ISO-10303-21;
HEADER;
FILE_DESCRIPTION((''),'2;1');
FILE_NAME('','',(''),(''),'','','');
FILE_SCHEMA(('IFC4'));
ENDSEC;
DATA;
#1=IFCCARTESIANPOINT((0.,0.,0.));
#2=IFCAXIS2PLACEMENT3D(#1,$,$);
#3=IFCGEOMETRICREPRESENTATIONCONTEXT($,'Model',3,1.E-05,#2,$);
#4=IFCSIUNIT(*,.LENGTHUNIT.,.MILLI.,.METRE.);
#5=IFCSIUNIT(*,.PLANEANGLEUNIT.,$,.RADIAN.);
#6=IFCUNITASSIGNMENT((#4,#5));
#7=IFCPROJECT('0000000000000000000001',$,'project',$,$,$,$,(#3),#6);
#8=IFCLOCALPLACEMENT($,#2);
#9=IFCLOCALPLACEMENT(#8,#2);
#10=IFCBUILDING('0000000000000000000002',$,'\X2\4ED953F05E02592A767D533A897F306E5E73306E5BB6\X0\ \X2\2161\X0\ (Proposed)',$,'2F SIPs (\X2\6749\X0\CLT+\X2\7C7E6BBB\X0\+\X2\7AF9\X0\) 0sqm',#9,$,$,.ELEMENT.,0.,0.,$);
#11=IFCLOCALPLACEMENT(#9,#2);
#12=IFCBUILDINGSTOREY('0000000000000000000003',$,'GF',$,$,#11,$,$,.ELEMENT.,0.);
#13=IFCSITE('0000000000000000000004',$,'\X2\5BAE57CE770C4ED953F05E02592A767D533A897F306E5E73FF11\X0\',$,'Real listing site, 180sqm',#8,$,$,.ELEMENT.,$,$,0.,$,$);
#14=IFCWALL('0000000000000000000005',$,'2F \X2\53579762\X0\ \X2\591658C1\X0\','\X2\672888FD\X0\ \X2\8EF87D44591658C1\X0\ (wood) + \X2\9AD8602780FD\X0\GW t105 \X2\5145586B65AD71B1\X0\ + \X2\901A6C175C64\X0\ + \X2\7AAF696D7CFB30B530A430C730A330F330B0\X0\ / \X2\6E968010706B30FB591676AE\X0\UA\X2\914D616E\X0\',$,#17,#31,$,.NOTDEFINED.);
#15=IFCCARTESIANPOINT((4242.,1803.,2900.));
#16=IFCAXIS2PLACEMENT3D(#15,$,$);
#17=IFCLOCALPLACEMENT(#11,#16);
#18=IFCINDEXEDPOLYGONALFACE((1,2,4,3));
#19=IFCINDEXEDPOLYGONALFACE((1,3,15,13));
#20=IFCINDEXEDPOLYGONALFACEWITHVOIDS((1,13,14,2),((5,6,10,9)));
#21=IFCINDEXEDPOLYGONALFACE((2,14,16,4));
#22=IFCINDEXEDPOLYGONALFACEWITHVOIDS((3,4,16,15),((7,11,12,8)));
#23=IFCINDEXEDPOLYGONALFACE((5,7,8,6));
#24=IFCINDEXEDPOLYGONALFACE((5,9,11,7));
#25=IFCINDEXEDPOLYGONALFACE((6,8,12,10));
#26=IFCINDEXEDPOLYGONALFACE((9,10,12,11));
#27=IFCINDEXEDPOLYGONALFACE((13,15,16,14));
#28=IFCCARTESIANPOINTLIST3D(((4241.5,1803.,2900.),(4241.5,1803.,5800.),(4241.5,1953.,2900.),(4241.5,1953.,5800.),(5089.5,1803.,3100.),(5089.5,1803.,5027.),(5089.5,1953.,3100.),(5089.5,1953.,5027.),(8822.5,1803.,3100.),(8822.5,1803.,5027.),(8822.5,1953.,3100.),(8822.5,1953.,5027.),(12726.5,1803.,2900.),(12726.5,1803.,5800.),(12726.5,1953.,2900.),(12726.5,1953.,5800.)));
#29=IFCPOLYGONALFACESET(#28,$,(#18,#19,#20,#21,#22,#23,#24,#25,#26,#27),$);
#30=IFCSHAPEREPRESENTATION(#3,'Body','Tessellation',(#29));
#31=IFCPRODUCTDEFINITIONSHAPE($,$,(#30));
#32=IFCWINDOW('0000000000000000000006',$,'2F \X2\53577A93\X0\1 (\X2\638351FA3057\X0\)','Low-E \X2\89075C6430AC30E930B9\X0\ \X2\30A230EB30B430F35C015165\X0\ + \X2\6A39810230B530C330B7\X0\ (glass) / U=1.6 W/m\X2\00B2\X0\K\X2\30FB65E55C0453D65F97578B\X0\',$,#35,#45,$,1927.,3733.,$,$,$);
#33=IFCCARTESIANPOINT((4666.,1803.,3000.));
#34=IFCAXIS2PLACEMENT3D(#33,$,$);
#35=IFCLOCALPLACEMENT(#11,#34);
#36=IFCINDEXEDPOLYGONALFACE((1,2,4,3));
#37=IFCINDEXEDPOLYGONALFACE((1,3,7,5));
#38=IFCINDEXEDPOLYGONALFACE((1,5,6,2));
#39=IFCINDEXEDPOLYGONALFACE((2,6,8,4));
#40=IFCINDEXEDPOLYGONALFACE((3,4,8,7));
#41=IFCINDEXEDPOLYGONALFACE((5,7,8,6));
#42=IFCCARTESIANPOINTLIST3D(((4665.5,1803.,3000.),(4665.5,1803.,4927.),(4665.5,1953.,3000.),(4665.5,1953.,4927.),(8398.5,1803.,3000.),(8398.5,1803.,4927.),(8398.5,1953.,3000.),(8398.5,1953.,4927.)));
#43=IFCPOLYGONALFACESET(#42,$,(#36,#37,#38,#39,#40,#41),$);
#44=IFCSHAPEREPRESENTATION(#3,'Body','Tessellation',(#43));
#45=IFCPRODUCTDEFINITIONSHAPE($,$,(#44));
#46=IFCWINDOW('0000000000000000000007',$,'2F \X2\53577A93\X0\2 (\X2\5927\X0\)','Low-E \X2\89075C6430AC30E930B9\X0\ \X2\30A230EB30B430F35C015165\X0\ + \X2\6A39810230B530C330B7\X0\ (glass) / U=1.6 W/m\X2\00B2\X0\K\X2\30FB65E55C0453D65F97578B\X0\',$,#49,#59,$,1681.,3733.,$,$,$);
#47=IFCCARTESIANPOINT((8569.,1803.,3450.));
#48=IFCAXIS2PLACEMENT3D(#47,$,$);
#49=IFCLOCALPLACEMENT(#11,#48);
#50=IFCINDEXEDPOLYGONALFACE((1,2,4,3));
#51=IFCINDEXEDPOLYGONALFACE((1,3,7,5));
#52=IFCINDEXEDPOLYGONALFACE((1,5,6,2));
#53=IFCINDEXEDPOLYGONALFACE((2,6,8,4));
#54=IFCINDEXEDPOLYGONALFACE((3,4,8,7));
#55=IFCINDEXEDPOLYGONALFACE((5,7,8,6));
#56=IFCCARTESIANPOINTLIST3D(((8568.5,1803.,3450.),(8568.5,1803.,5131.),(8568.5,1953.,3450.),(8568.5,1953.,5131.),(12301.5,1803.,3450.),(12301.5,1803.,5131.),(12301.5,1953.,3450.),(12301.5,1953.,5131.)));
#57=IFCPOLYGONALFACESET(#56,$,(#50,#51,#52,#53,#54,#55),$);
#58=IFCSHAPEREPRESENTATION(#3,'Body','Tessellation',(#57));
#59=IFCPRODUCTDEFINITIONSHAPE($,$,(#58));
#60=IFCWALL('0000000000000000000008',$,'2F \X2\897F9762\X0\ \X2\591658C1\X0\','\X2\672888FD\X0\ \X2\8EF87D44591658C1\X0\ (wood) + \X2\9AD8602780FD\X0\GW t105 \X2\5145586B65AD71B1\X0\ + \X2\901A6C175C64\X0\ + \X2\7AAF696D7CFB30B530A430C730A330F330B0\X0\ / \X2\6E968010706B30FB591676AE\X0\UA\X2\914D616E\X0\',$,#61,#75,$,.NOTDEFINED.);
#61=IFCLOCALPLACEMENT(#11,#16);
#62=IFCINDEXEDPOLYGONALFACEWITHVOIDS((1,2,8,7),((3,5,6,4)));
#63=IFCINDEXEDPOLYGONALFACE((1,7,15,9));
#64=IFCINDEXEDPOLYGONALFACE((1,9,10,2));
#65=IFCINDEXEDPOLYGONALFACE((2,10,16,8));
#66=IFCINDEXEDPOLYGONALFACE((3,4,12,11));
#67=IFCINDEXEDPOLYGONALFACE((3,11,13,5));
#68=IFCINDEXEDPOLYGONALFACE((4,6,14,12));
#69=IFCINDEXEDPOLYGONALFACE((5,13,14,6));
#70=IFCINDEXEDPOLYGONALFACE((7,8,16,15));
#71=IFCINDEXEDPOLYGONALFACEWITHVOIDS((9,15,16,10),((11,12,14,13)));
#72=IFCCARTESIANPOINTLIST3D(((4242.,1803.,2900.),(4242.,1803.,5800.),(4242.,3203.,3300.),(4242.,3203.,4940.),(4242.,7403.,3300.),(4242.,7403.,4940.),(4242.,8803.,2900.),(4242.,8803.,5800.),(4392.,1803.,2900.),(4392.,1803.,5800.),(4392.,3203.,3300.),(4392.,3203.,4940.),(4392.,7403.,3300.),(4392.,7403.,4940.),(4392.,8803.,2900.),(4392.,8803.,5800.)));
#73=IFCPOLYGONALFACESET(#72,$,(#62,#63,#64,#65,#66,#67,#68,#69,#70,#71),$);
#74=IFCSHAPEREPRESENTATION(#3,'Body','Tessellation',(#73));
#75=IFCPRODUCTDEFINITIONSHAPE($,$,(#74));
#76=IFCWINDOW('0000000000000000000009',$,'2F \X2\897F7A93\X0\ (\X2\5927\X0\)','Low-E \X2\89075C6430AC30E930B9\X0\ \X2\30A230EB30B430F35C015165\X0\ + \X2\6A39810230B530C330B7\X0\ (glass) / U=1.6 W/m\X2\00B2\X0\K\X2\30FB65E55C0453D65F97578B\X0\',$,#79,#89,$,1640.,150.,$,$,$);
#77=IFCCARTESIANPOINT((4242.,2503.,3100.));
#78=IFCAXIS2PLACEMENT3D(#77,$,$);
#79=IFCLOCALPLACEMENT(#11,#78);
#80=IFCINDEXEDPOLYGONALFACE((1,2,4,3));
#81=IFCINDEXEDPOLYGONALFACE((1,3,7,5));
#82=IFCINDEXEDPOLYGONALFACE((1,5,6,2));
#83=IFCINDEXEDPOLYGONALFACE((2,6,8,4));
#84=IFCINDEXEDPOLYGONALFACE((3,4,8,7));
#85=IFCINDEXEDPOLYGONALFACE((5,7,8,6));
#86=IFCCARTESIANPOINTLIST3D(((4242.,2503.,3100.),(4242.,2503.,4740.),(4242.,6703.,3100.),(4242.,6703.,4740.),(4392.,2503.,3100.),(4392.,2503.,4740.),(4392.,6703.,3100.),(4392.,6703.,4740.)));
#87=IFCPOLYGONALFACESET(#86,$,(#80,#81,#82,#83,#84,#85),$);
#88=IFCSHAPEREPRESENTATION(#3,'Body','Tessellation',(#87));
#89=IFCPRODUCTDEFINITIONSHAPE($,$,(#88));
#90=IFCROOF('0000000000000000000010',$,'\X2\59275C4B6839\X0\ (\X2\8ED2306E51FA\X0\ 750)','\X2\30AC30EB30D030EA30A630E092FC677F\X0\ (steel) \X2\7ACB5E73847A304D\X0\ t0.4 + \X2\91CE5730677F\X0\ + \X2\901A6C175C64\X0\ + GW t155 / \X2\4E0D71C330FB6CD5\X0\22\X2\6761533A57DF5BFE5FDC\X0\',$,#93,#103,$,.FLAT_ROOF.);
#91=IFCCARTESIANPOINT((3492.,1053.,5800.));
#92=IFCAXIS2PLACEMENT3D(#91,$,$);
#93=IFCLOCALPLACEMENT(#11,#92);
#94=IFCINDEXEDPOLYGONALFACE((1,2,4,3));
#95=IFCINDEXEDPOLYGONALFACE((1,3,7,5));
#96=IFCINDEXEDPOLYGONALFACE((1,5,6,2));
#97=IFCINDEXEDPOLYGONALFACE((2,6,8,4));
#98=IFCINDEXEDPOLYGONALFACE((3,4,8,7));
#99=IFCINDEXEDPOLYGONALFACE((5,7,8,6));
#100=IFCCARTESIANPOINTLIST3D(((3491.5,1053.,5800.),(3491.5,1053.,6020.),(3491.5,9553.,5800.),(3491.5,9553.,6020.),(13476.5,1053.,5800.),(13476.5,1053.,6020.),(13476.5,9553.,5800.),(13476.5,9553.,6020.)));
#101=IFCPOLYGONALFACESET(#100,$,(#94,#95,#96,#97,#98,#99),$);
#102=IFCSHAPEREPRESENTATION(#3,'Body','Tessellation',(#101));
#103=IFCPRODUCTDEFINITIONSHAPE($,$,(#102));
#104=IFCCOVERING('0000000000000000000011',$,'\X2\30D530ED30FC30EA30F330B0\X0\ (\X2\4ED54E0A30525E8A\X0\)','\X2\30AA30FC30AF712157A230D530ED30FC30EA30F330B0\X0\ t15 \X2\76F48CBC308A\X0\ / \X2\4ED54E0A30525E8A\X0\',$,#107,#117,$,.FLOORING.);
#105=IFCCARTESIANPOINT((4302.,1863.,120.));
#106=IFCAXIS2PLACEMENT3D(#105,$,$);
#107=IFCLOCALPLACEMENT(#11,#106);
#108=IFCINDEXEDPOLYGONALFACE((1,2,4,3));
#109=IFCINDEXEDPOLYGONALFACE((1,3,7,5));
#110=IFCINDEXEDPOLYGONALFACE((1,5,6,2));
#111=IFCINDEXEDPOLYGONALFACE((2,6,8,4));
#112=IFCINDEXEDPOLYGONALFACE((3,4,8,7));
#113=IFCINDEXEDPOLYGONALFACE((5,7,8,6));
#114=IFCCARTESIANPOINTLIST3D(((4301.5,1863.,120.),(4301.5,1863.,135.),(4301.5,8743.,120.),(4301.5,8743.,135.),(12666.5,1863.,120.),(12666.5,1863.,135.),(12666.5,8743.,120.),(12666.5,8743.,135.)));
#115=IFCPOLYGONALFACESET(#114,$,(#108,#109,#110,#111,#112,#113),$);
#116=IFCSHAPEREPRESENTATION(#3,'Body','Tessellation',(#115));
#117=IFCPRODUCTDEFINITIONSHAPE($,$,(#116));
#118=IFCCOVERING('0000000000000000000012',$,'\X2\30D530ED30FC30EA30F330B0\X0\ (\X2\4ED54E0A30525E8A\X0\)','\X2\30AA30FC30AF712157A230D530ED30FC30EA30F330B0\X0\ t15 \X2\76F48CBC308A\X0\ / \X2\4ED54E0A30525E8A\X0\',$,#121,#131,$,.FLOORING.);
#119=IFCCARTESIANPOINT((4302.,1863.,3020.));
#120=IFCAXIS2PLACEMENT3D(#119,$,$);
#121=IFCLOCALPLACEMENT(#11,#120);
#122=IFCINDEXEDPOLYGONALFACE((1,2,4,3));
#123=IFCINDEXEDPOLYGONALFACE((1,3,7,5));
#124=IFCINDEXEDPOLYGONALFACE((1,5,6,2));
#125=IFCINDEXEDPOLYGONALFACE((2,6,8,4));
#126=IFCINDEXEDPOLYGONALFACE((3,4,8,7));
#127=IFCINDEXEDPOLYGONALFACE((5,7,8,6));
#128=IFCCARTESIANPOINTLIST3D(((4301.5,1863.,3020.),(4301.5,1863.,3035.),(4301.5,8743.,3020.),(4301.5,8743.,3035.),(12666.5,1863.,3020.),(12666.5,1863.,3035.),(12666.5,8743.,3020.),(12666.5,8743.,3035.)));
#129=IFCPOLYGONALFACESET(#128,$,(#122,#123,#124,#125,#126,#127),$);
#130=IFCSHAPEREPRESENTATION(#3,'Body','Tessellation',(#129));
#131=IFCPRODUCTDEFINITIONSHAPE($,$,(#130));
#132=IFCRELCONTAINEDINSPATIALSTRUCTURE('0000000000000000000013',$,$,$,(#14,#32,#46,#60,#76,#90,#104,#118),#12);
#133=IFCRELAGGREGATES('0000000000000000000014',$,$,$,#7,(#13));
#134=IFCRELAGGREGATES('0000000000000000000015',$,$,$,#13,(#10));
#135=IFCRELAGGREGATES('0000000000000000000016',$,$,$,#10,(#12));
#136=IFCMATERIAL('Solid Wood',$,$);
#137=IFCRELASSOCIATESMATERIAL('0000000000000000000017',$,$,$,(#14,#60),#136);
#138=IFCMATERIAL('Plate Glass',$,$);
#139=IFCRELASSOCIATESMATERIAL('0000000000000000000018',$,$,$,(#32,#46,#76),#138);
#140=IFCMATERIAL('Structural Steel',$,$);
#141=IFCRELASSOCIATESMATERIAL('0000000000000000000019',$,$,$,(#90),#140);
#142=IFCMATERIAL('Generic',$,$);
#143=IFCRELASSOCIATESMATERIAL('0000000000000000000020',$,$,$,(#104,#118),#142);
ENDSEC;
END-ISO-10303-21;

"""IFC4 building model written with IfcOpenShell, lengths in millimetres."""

from ifc_helpers import new_model, si_unit, frame, frame_2d, origin, place, context, project, spatial, rectangle, extrude, material, element, fill, save


model = new_model("IFC4")

# Units and contexts
model_context = context("Model", 3, precision=1e-05, world=origin())
ifc_project = project(units=[si_unit("LENGTHUNIT", "METRE", prefix="MILLI"), si_unit("PLANEANGLEUNIT", "RADIAN")], contexts=[model_context])

# Site, building, storey
site_placement = place(None, origin())
site = spatial("IfcSite", under=ifc_project, at=site_placement, Name="宮城県仙台市太白区西の平１", ObjectType="Real listing site, 180sqm", CompositionType="ELEMENT", RefElevation=0.0)
building_placement = place(site_placement, origin())
building = spatial("IfcBuilding", under=site, at=building_placement, Name="仙台市太白区西の平の家 Ⅱ (Proposed)", ObjectType="2F SIPs (杉CLT+籾殻+竹) 0sqm", CompositionType="ELEMENT", ElevationOfRefHeight=0.0, ElevationOfTerrain=0.0)
storey_placement = place(building_placement, origin())
storey = spatial("IfcBuildingStorey", under=building, at=storey_placement, Name="GF", CompositionType="ELEMENT", Elevation=0.0)

# Shared definitions
ifc_material_1 = material(Name="Solid Wood")

# Shared definitions
ifc_material_2 = material(Name="Plate Glass")

# Wall, openings, windows
wall_1_placement = place(storey_placement, frame((4242.0, 1803.0, 2900.0)))
wall_1 = element("IfcWall", 1, at=wall_1_placement, inside=storey, material=ifc_material_1, Name="2F 南面 外壁", Description="木製 軸組外壁 (wood) + 高性能GW t105 充填断熱 + 通気層 + 窯業系サイディング / 準耐火・外皮UA配慮", PredefinedType="NOTDEFINED", context=model_context, shape_type="SweptSolid", body=[
    extrude(rectangle(XDim=8485.0, YDim=150.0, at=frame_2d((4242.0, 75.0))), frame((4242.0, 1803.0, 2900.0)), (0.0, 0.0, 1.0), 2900.0),
])
opening_1_placement = place(storey_placement, frame((4666.0, 1803.0, 3000.0)))
opening_1 = element("IfcOpeningElement", 2, at=opening_1_placement, cuts=wall_1, PredefinedType="NOTDEFINED", context=model_context, shape_type="SweptSolid", body=[
    extrude(rectangle(XDim=3733.0, YDim=150.0, at=frame_2d((1866.0, 75.0))), frame((4666.0, 1803.0, 3000.0)), (0.0, 0.0, 1.0), 1927.0),
])
opening_2_placement = place(storey_placement, frame((8569.0, 1803.0, 3450.0)))
opening_2 = element("IfcOpeningElement", 3, at=opening_2_placement, cuts=wall_1, PredefinedType="NOTDEFINED", context=model_context, shape_type="SweptSolid", body=[
    extrude(rectangle(XDim=3733.0, YDim=150.0, at=frame_2d((1866.0, 75.0))), frame((8569.0, 1803.0, 3450.0)), (0.0, 0.0, 1.0), 1681.0),
])
window_1_placement = place(storey_placement, frame((4666.0, 1803.0, 3000.0)))
window_1 = element("IfcWindow", 4, at=window_1_placement, inside=storey, material=ifc_material_2, Name="2F 南窓1 (掃出し)", Description="Low-E 複層ガラス アルゴン封入 + 樹脂サッシ (glass) / U=1.6 W/m²K・日射取得型", OverallHeight=1927.0, OverallWidth=3733.0, context=model_context, shape_type="SweptSolid", body=[
    extrude(rectangle(XDim=3733.0, YDim=150.0, at=frame_2d((1866.0, 75.0))), frame((4666.0, 1803.0, 3000.0)), (0.0, 0.0, 1.0), 1927.0),
])
fill(opening_1, window_1)
window_2_placement = place(storey_placement, frame((8569.0, 1803.0, 3450.0)))
window_2 = element("IfcWindow", 5, at=window_2_placement, inside=storey, material=ifc_material_2, Name="2F 南窓2 (大)", Description="Low-E 複層ガラス アルゴン封入 + 樹脂サッシ (glass) / U=1.6 W/m²K・日射取得型", OverallHeight=1681.0, OverallWidth=3733.0, context=model_context, shape_type="SweptSolid", body=[
    extrude(rectangle(XDim=3733.0, YDim=150.0, at=frame_2d((1866.0, 75.0))), frame((8569.0, 1803.0, 3450.0)), (0.0, 0.0, 1.0), 1681.0),
])
fill(opening_2, window_2)

# Wall, opening, window
wall_2_placement = place(storey_placement, frame((4242.0, 1803.0, 2900.0)))
wall_2 = element("IfcWall", 6, at=wall_2_placement, inside=storey, material=ifc_material_1, Name="2F 西面 外壁", Description="木製 軸組外壁 (wood) + 高性能GW t105 充填断熱 + 通気層 + 窯業系サイディング / 準耐火・外皮UA配慮", PredefinedType="NOTDEFINED", context=model_context, shape_type="SweptSolid", body=[
    extrude(rectangle(XDim=150.0, YDim=7000.0, at=frame_2d((75.0, 3500.0))), frame((4242.0, 1803.0, 2900.0)), (0.0, 0.0, 1.0), 2900.0),
])
opening_3_placement = place(storey_placement, frame((4242.0, 2503.0, 3100.0)))
opening_3 = element("IfcOpeningElement", 7, at=opening_3_placement, cuts=wall_2, PredefinedType="NOTDEFINED", context=model_context, shape_type="SweptSolid", body=[
    extrude(rectangle(XDim=150.0, YDim=4200.0, at=frame_2d((75.0, 2100.0))), frame((4242.0, 2503.0, 3100.0)), (0.0, 0.0, 1.0), 1640.0),
])
window_3_placement = place(storey_placement, frame((4242.0, 2503.0, 3100.0)))
window_3 = element("IfcWindow", 8, at=window_3_placement, inside=storey, material=ifc_material_2, Name="2F 西窓 (大)", Description="Low-E 複層ガラス アルゴン封入 + 樹脂サッシ (glass) / U=1.6 W/m²K・日射取得型", OverallHeight=1640.0, OverallWidth=150.0, context=model_context, shape_type="SweptSolid", body=[
    extrude(rectangle(XDim=150.0, YDim=4200.0, at=frame_2d((75.0, 2100.0))), frame((4242.0, 2503.0, 3100.0)), (0.0, 0.0, 1.0), 1640.0),
])
fill(opening_3, window_3)

# Roof
ifc_material_3 = material(Name="Structural Steel")
roof_placement = place(storey_placement, frame((3492.0, 1053.0, 5800.0)))
element("IfcRoof", 9, at=roof_placement, inside=storey, material=ifc_material_3, Name="大屋根 (軒の出 750)", Description="ガルバリウム鋼板 (steel) 立平葺き t0.4 + 野地板 + 通気層 + GW t155 / 不燃・法22条区域対応", PredefinedType="FLAT_ROOF", context=model_context, shape_type="SweptSolid", body=[
    extrude(rectangle(XDim=9985.0, YDim=8500.0, at=frame_2d((4992.0, 4250.0))), frame((3492.0, 1053.0, 5800.0)), (0.0, 0.0, 1.0), 220.0),
])

# Coverings
ifc_material_4 = material(Name="Generic")
covering_1_placement = place(storey_placement, frame((4302.0, 1863.0, 120.0)))
element("IfcCovering", 10, at=covering_1_placement, inside=storey, material=ifc_material_4, Name="フローリング (仕上げ床)", Description="オーク無垢フローリング t15 直貼り / 仕上げ床", PredefinedType="FLOORING", context=model_context, shape_type="SweptSolid", body=[
    extrude(rectangle(XDim=8365.0, YDim=6880.0, at=frame_2d((4182.0, 3440.0))), frame((4302.0, 1863.0, 120.0)), (0.0, 0.0, 1.0), 15.0),
])
covering_2_placement = place(storey_placement, frame((4302.0, 1863.0, 3020.0)))
element("IfcCovering", 11, at=covering_2_placement, inside=storey, material=ifc_material_4, Name="フローリング (仕上げ床)", Description="オーク無垢フローリング t15 直貼り / 仕上げ床", PredefinedType="FLOORING", context=model_context, shape_type="SweptSolid", body=[
    extrude(rectangle(XDim=8365.0, YDim=6880.0, at=frame_2d((4182.0, 3440.0))), frame((4302.0, 1863.0, 3020.0)), (0.0, 0.0, 1.0), 15.0),
])

save(model, "model.ifc")
